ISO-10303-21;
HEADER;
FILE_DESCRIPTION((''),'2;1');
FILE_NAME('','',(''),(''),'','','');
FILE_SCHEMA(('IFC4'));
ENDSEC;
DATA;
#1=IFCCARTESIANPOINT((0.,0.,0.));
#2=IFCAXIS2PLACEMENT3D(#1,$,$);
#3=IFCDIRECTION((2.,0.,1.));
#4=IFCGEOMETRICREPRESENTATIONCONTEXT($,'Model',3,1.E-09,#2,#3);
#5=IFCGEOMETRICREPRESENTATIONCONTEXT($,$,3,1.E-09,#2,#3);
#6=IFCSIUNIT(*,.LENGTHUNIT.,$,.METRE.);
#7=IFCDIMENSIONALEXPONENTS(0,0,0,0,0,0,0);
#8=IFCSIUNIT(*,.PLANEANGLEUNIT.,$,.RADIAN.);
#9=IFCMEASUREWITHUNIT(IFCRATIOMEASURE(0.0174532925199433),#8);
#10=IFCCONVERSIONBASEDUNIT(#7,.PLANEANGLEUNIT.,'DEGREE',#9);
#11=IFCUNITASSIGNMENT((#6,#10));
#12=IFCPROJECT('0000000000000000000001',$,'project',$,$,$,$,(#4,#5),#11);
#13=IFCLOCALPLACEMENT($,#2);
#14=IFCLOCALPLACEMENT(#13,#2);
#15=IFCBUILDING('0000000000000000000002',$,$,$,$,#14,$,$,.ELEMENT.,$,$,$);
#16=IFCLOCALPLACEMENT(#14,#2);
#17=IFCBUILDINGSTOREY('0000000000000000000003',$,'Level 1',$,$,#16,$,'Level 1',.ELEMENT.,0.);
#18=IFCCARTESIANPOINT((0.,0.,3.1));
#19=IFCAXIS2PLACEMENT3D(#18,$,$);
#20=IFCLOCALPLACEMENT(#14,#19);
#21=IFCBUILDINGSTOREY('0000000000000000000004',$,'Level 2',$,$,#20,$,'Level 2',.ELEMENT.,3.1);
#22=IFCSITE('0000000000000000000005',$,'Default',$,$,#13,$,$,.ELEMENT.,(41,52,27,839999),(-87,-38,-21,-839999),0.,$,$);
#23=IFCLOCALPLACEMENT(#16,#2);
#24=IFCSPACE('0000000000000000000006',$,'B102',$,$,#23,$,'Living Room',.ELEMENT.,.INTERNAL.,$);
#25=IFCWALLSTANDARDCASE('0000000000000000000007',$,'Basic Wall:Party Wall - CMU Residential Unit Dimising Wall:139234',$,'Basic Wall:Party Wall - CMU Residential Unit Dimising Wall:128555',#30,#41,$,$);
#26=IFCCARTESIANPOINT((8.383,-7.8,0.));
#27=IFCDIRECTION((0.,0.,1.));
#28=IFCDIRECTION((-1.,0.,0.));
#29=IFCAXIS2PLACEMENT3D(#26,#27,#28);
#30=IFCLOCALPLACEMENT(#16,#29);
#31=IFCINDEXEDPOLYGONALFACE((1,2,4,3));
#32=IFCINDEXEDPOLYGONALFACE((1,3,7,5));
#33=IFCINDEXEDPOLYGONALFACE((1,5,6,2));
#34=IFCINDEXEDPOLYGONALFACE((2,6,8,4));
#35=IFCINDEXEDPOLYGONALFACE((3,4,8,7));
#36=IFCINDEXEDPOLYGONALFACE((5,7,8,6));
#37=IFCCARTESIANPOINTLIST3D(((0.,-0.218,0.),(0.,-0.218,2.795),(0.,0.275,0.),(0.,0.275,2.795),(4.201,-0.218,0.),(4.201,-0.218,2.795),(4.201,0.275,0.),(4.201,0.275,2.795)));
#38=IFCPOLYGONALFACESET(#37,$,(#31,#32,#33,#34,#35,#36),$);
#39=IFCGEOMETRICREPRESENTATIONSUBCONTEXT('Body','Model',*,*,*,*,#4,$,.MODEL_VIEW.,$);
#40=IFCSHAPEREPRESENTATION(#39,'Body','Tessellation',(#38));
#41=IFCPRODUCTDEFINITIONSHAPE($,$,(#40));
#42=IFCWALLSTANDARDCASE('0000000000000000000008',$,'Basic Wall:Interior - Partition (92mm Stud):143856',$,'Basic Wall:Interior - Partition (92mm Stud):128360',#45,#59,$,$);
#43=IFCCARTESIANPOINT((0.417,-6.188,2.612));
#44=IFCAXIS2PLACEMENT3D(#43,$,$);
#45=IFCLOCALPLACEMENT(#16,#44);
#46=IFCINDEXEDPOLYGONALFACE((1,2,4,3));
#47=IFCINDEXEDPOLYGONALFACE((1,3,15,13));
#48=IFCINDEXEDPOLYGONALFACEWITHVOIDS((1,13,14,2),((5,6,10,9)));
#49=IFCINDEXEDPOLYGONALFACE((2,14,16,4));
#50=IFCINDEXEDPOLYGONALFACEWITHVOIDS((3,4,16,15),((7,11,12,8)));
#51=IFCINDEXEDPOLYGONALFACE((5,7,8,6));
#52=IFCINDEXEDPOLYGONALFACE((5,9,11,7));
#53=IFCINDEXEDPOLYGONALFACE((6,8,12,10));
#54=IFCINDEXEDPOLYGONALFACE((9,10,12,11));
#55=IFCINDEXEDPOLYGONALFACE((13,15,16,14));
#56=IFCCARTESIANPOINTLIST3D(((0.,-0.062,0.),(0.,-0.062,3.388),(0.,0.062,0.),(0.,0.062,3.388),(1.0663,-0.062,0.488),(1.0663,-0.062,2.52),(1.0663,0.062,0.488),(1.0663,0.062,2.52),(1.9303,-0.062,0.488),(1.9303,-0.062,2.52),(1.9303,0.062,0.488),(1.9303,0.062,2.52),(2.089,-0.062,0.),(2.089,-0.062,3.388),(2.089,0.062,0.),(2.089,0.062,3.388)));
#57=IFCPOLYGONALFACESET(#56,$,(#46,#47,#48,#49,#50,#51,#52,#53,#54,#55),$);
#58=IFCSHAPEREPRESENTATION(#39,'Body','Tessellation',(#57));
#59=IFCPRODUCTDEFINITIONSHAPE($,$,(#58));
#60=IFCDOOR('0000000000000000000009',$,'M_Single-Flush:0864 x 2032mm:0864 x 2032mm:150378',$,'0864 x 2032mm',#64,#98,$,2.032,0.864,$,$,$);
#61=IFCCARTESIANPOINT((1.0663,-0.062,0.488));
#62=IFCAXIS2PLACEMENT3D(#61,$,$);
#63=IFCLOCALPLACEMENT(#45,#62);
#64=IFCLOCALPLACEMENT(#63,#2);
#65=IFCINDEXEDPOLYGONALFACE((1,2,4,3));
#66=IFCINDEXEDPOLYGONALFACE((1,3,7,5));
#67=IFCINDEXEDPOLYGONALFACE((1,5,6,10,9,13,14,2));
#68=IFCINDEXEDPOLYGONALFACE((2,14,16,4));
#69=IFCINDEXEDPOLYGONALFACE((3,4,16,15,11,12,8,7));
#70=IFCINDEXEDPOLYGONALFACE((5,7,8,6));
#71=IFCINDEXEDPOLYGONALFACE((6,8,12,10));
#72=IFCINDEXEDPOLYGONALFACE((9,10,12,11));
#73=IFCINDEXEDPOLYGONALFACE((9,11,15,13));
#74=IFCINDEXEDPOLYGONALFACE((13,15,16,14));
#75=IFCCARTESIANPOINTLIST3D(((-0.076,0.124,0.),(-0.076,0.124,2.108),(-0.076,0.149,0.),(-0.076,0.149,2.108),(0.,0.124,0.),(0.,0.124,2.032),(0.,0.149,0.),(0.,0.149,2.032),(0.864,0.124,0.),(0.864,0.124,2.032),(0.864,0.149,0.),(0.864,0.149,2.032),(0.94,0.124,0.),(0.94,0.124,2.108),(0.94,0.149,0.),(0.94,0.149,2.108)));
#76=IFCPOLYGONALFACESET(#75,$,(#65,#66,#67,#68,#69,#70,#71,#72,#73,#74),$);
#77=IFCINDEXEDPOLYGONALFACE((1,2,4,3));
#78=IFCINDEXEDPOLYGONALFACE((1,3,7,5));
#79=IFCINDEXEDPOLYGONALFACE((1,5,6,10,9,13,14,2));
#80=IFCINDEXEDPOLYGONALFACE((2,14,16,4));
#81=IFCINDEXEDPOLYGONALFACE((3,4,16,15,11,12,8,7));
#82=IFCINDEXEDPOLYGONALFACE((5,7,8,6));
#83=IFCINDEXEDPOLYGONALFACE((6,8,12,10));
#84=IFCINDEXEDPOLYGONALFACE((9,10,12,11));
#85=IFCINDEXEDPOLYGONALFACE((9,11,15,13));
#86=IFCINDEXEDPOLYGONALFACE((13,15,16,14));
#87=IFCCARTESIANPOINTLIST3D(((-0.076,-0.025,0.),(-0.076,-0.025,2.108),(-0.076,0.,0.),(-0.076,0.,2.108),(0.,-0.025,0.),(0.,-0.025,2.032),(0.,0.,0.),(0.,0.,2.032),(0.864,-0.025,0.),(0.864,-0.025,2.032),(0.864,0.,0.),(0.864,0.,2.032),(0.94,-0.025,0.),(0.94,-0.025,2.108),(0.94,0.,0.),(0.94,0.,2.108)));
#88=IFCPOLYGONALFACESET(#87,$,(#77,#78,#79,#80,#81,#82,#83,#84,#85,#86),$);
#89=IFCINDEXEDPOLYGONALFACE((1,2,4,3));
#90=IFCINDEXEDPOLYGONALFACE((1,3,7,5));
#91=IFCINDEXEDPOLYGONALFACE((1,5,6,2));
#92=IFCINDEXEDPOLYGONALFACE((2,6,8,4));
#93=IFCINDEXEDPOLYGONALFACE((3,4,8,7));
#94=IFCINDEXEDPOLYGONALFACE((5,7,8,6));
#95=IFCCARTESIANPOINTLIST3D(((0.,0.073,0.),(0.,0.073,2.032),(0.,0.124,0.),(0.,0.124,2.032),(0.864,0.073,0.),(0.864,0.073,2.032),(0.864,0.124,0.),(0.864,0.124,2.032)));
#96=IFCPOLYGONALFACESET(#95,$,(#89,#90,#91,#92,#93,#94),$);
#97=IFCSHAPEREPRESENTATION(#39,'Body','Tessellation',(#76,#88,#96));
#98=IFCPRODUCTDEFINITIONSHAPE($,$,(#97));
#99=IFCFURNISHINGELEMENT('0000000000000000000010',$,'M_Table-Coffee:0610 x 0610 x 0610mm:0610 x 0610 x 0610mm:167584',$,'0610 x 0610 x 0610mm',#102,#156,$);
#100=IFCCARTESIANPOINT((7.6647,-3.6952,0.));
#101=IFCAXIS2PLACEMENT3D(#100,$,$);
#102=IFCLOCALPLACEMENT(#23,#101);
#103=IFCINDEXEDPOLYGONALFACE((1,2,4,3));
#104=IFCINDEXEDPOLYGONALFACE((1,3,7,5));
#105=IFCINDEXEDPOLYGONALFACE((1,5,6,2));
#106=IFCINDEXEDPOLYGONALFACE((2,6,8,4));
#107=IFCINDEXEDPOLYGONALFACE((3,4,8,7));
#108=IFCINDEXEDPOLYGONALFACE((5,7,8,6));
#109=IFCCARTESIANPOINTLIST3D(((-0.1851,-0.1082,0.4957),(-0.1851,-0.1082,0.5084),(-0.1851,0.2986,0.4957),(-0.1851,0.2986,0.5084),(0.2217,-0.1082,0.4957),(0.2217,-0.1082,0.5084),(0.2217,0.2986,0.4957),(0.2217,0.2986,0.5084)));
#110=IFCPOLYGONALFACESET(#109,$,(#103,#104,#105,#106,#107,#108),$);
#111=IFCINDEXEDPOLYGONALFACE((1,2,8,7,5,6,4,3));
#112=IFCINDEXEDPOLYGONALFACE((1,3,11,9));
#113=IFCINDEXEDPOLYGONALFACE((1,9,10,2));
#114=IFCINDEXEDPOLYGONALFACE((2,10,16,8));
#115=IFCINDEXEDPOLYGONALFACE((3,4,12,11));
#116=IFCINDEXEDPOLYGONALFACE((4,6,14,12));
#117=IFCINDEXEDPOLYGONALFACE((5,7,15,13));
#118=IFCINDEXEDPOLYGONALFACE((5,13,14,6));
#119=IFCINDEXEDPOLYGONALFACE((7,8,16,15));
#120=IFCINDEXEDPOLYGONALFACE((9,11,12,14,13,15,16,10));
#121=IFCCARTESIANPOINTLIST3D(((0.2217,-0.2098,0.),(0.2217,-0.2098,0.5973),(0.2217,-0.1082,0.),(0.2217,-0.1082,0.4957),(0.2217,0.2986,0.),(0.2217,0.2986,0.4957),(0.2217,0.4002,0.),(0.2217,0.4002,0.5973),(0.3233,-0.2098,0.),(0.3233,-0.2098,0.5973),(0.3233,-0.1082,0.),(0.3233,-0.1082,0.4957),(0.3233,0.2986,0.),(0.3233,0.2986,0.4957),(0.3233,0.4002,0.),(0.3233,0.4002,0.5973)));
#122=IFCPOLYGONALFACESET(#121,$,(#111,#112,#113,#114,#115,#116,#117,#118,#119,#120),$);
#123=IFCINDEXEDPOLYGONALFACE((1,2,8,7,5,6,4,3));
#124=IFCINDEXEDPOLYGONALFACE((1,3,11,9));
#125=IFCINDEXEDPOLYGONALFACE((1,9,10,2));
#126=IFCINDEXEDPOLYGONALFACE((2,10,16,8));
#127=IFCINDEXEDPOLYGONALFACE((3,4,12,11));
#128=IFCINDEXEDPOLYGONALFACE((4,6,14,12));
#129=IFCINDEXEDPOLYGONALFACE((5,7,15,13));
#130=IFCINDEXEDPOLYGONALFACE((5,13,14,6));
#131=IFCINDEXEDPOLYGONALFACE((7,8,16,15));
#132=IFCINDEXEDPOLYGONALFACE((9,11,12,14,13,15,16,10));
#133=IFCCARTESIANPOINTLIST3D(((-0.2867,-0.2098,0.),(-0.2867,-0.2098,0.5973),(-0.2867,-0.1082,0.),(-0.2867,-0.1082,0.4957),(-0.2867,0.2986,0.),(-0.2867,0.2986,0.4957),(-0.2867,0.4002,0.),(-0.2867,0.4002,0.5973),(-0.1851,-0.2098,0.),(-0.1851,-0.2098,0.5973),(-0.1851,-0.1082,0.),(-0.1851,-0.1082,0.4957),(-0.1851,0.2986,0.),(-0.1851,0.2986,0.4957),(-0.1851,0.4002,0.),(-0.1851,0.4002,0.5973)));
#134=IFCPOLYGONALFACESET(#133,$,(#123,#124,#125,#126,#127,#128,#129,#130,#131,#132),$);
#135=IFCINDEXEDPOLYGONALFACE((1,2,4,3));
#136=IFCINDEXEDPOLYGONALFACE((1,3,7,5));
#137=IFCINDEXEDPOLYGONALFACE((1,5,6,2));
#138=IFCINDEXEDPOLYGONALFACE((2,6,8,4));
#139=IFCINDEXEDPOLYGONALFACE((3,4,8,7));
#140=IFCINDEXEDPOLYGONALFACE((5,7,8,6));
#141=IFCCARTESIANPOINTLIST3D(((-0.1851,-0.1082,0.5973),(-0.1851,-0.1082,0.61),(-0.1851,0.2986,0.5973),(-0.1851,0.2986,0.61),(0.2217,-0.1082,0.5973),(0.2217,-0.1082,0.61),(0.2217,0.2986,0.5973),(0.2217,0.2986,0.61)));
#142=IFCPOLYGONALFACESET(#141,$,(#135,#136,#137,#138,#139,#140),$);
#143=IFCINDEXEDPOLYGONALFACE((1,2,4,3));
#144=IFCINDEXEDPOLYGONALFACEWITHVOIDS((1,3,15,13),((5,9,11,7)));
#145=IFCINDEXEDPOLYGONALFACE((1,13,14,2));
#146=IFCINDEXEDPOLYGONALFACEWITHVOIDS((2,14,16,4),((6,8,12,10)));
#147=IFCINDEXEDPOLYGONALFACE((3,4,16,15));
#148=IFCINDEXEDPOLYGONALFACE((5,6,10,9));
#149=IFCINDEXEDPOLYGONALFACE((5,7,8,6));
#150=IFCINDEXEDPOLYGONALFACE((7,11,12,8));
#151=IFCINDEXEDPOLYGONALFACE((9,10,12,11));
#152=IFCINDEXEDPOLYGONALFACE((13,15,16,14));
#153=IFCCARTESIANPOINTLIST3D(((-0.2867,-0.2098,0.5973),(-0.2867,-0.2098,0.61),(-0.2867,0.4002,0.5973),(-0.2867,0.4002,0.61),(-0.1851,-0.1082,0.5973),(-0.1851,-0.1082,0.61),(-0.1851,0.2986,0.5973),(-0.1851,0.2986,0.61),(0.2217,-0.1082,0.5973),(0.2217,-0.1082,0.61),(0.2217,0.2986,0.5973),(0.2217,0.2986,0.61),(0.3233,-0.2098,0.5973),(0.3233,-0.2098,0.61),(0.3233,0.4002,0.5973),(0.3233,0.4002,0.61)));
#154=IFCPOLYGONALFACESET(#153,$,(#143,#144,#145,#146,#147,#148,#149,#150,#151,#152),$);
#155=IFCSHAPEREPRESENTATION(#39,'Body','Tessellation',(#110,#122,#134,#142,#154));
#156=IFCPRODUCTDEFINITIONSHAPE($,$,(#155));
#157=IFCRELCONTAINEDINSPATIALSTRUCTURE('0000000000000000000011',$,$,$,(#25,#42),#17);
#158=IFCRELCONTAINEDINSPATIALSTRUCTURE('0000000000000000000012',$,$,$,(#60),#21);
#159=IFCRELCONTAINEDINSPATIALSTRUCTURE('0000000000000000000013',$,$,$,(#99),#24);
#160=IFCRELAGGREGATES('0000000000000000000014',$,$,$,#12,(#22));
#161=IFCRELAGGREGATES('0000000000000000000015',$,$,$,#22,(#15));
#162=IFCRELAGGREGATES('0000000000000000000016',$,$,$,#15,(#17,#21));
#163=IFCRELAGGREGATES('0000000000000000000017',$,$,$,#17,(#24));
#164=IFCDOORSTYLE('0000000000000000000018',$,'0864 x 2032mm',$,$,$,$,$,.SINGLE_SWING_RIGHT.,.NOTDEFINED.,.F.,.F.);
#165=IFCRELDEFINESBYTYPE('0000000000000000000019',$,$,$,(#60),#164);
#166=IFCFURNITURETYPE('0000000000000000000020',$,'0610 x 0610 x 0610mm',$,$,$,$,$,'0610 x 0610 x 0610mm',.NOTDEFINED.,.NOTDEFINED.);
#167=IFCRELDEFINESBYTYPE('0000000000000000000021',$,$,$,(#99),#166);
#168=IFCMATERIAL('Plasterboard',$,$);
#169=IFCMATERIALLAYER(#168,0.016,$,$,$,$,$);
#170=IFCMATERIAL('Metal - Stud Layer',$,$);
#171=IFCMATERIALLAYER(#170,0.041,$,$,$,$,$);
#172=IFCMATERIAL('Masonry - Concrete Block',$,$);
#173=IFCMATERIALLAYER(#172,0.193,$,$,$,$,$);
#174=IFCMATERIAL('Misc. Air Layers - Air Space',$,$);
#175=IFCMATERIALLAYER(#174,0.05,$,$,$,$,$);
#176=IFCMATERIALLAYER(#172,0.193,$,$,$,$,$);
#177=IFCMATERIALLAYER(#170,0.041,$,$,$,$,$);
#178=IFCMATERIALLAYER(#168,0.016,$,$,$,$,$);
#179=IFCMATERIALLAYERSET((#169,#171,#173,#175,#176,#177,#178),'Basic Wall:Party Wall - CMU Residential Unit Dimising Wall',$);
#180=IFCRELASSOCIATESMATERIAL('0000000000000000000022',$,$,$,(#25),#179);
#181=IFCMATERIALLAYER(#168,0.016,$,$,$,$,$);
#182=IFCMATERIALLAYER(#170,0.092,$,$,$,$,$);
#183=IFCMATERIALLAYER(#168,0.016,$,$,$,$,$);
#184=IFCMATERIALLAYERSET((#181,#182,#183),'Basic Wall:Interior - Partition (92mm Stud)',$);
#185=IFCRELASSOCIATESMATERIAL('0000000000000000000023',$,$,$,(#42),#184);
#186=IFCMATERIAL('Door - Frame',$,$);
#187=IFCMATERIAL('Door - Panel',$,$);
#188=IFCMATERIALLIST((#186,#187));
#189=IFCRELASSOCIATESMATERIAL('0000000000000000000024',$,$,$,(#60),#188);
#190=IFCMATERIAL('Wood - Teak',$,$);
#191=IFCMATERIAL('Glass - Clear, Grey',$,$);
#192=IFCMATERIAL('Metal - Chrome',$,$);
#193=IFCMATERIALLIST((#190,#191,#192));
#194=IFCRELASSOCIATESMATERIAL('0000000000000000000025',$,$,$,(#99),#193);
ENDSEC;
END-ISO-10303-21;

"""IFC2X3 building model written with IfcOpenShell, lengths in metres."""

from ifc_helpers import new_model, entity, si_unit, converted_unit, direction, frame, frame_2d, origin, origin_2d_with_axis, place, context, subcontext, project, spatial, polyline, rectangle, outline, extrude, clip, bounded_halfspace, source, transform, mapped, material, material_list, layer, layer_set, layer_usage, type_object, type_shapes, element, fill, save


model = new_model("IFC2X3")

# Units and contexts
model_context = context("Model", 3, precision=1e-09, world=origin(), true_north=direction((2.0, 0.0, 1.0)))
context_of_model = context(None, 3, precision=1e-09, world=origin(), true_north=direction((2.0, 0.0, 1.0)))
body_context = subcontext(model_context, "Body", "Model", "MODEL_VIEW")
ifc_project = project(units=[si_unit("LENGTHUNIT", "METRE"), converted_unit("PLANEANGLEUNIT", "DEGREE", entity("IfcRatioMeasure", 0.0174532925199433), si_unit("PLANEANGLEUNIT", "RADIAN"), dimensions=[0, 0, 0, 0, 0, 0, 0])], contexts=[model_context, context_of_model])

# Site, building, storey
site_placement = place(None, origin())
site = spatial("IfcSite", under=ifc_project, at=site_placement, Name="Default", CompositionType="ELEMENT", RefLatitude=(41, 52, 27, 839999), RefLongitude=(-87, -38, -21, -839999), RefElevation=0.0)
building_placement = place(site_placement, origin())
building = spatial("IfcBuilding", under=site, at=building_placement, CompositionType="ELEMENT")
storey_1_placement = place(building_placement, origin())
storey_1 = spatial("IfcBuildingStorey", under=building, at=storey_1_placement, Name="Level 1", LongName="Level 1", CompositionType="ELEMENT", Elevation=0.0)

# Shared definitions
ifc_material_1 = material(Name="Plasterboard")
ifc_layer_1 = layer(ifc_material_1, 0.016)
ifc_material_2 = material(Name="Metal - Stud Layer")
ifc_layer_2 = layer(ifc_material_2, 0.092)
ifc_layer_3 = layer(ifc_material_1, 0.016)
ifc_layer_set_1 = layer_set([ifc_layer_1, ifc_layer_2, ifc_layer_3], Name="Basic Wall:Interior - Partition (92mm Stud)")
ifc_material_3 = material(Name="Door - Frame")
ifc_material_4 = material(Name="Door - Panel")

# Wall
ifc_layer_4 = layer(ifc_material_1, 0.016)
ifc_layer_5 = layer(ifc_material_2, 0.041)
ifc_material_5 = material(Name="Masonry - Concrete Block")
ifc_layer_6 = layer(ifc_material_5, 0.193)
ifc_material_6 = material(Name="Misc. Air Layers - Air Space")
ifc_layer_7 = layer(ifc_material_6, 0.05)
ifc_layer_8 = layer(ifc_material_5, 0.193)
ifc_layer_9 = layer(ifc_material_2, 0.041)
ifc_layer_10 = layer(ifc_material_1, 0.016)
ifc_layer_set_2 = layer_set([ifc_layer_4, ifc_layer_5, ifc_layer_6, ifc_layer_7, ifc_layer_8, ifc_layer_9, ifc_layer_10], Name="Basic Wall:Party Wall - CMU Residential Unit Dimising Wall")
ifc_layer_usage_1 = layer_usage(ifc_layer_set_2, "AXIS2", "NEGATIVE", 0.275)
wall_1_placement = place(storey_1_placement, frame((8.383, -7.8, 0.0), z_axis=(0.0, 0.0, 1.0), x_axis=(-1.0, 0.0, 0.0)))
element("IfcWallStandardCase", 1, at=wall_1_placement, inside=storey_1, material=ifc_layer_usage_1, Name="Basic Wall:Party Wall - CMU Residential Unit Dimising Wall:139234", ObjectType="Basic Wall:Party Wall - CMU Residential Unit Dimising Wall:128555", context=body_context, shape_type="Clipping", body=[
    clip(clip(extrude(rectangle(XDim=4.201, YDim=0.55, at=frame_2d((2.1005, 0.0), x_axis=(-1.0, 0.0))), origin(), (0.0, 0.0, 1.0), 2.795), bounded_halfspace(frame((0.0, -0.218, 2.795), z_axis=(0.0, 1.0, 0.0), x_axis=(-1.0, 0.0, 0.0)), True, frame((0.0, -0.218, 2.795), z_axis=(0.0, 1.0, 0.0), x_axis=(-1.0, 0.0, 0.0)), polyline([(0.0, 0.0), (-3.708, 0.0), (-4.201, 0.0), (-4.201, -2.795), (0.0, -2.795), (0.0, 0.0)]))), bounded_halfspace(frame((4.201, 0.275, 0.0), z_axis=(-1.0, 0.0, 0.0), x_axis=(0.0, -1.0, 0.0)), True, frame((4.201, 0.275, 0.0), z_axis=(-1.0, 0.0, 0.0), x_axis=(0.0, -1.0, 0.0)), polyline([(0.0, 0.0), (0.493, 0.0), (0.493, 2.795), (0.0, 2.795), (0.0, 0.0)]))),
])

# Wall, opening
ifc_layer_usage_2 = layer_usage(ifc_layer_set_1, "AXIS2", "NEGATIVE", 0.062)
wall_2_placement = place(storey_1_placement, frame((0.417, -6.188, 2.612)))
wall_2 = element("IfcWallStandardCase", 2, at=wall_2_placement, inside=storey_1, material=ifc_layer_usage_2, Name="Basic Wall:Interior - Partition (92mm Stud):143856", ObjectType="Basic Wall:Interior - Partition (92mm Stud):128360", context=body_context, shape_type="SweptSolid", body=[
    extrude(rectangle(XDim=2.089, YDim=0.124, at=frame_2d((1.0445, 0.0), x_axis=(-1.0, 0.0))), origin(), (0.0, 0.0, 1.0), 3.388),
])
opening_1_placement = place(wall_2_placement, frame((1.0663, -0.062, 0.488)))
opening_1 = element("IfcOpeningElement", 3, at=opening_1_placement, cuts=wall_2, ObjectType="Opening", context=body_context, shape_type="SweptSolid", body=[
    extrude(rectangle(XDim=0.864, YDim=2.032, at=frame_2d((1.016, 0.432), x_axis=(0.0, 1.0))), frame((0.0, 0.0, 0.0), z_axis=(0.0, 1.0, 0.0), x_axis=(0.0, 0.0, 1.0)), (0.0, 0.0, 1.0), 0.124),
])

# Shared definitions
storey_2_placement = place(building_placement, frame((0.0, 0.0, 3.1)))
storey_2 = spatial("IfcBuildingStorey", under=building, at=storey_2_placement, Name="Level 2", LongName="Level 2", CompositionType="ELEMENT", Elevation=3.1)

# Door
ifc_material_list_1 = material_list([ifc_material_3, ifc_material_4])
door_style_1 = type_object("IfcDoorStyle", Name="0864 x 2032mm", ConstructionType="NOTDEFINED", OperationType="SINGLE_SWING_RIGHT", ParameterTakesPrecedence=False, Sizeable=False)
shared_shape_1 = source(origin(), body_context, "Body", "SweptSolid", [
    extrude(outline(polyline([(-0.508, -1.073), (0.508, -1.073), (0.508, 1.035), (0.432, 1.035), (0.432, -0.997), (-0.432, -0.997), (-0.432, 1.035), (-0.508, 1.035), (-0.508, -1.073)])), frame((0.432, 0.124, 1.035), z_axis=(0.0, 1.0, 0.0), x_axis=(1.0, 0.0, 0.0)), (0.0, 0.0, 1.0), 0.025),
    extrude(outline(polyline([(-1.073, -0.508), (1.035, -0.508), (1.035, -0.432), (-0.997, -0.432), (-0.997, 0.432), (1.035, 0.432), (1.035, 0.508), (-1.073, 0.508), (-1.073, -0.508)])), frame((0.432, -0.025, 1.035), z_axis=(0.0, 1.0, 0.0), x_axis=(0.0, 0.0, -1.0)), (0.0, 0.0, 1.0), 0.025),
    extrude(rectangle(XDim=0.051, YDim=0.864, at=origin_2d_with_axis()), frame((0.432, 0.0985, 0.0), z_axis=(0.0, 0.0, 1.0), x_axis=(0.0, 1.0, 0.0)), (0.0, 0.0, 1.0), 2.032),
])
type_shapes(door_style_1, [shared_shape_1])
door_1_placement = place(opening_1_placement, origin())
door_1 = element("IfcDoor", 4, at=door_1_placement, inside=storey_2, type_object=door_style_1, material=ifc_material_list_1, Name="M_Single-Flush:0864 x 2032mm:0864 x 2032mm:150378", ObjectType="0864 x 2032mm", OverallHeight=2.032, OverallWidth=0.864, context=body_context, shape_type="MappedRepresentation", body=[
    mapped(shared_shape_1, transform((0.0, 0.0, 0.0), scale=1.0)),
])
fill(opening_1, door_1)

# Shared definitions
space_1_placement = place(storey_1_placement, origin())
space_1 = spatial("IfcSpace", under=storey_1, at=space_1_placement, Name="B102", LongName="Living Room", CompositionType="ELEMENT", InteriorOrExteriorSpace="INTERNAL")

# Furnishing element
ifc_material_7 = material(Name="Wood - Teak")
ifc_material_8 = material(Name="Glass - Clear, Grey")
ifc_material_9 = material(Name="Metal - Chrome")
ifc_material_list_2 = material_list([ifc_material_7, ifc_material_8, ifc_material_9])
furniture_type_1 = type_object("IfcFurnitureType", Name="0610 x 0610 x 0610mm", ElementType="0610 x 0610 x 0610mm", AssemblyPlace="NOTDEFINED")
shared_shape_2 = source(origin(), body_context, "Body", "SweptSolid", [
    extrude(rectangle(XDim=0.4068, YDim=0.4068, at=origin_2d_with_axis()), frame((0.0183, 0.0952, 0.4957), z_axis=(0.0, 0.0, 1.0), x_axis=(-1.0, 0.0, 0.0)), (0.0, 0.0, 1.0), 0.0127),
    extrude(outline(polyline([(-0.2732, -0.305), (0.324, -0.305), (0.324, 0.305), (-0.2732, 0.305), (-0.2732, 0.2034), (0.2225, 0.2034), (0.2225, -0.2034), (-0.2732, -0.2034), (-0.2732, -0.305)])), frame((0.2217, 0.0952, 0.2732), z_axis=(1.0, 0.0, 0.0), x_axis=(0.0, 0.0, 1.0)), (0.0, 0.0, 1.0), 0.1016),
    extrude(outline(polyline([(-0.305, -0.3241), (0.305, -0.3241), (0.305, 0.2733), (0.2034, 0.2733), (0.2034, -0.2224), (-0.2034, -0.2224), (-0.2034, 0.2733), (-0.305, 0.2733), (-0.305, -0.3241)])), frame((-0.2867, 0.0952, 0.2733), z_axis=(1.0, 0.0, 0.0), x_axis=(0.0, -1.0, 0.0)), (0.0, 0.0, 1.0), 0.1016),
    extrude(rectangle(XDim=0.4068, YDim=0.4068, at=origin_2d_with_axis()), frame((0.0183, 0.0952, 0.5973), z_axis=(0.0, 0.0, 1.0), x_axis=(-1.0, 0.0, 0.0)), (0.0, 0.0, 1.0), 0.0127),
    extrude(outline(polyline([(-0.305, -0.305), (0.305, -0.305), (0.305, 0.305), (-0.305, 0.305), (-0.305, -0.305)]), holes=[polyline([(-0.2034, -0.2034), (-0.2034, 0.2034), (0.2034, 0.2034), (0.2034, -0.2034), (-0.2034, -0.2034)])]), frame((0.0183, 0.0952, 0.5973), z_axis=(0.0, 0.0, 1.0), x_axis=(-1.0, 0.0, 0.0)), (0.0, 0.0, 1.0), 0.0127),
])
type_shapes(furniture_type_1, [shared_shape_2])
furnishing_1_placement = place(space_1_placement, frame((7.6647, -3.6952, 0.0)))
element("IfcFurnishingElement", 5, at=furnishing_1_placement, inside=space_1, type_object=furniture_type_1, material=ifc_material_list_2, Name="M_Table-Coffee:0610 x 0610 x 0610mm:0610 x 0610 x 0610mm:167584", ObjectType="0610 x 0610 x 0610mm", context=body_context, shape_type="MappedRepresentation", body=[
    mapped(shared_shape_2, transform((0.0, 0.0, 0.0), scale=1.0)),
])

save(model, "model.ifc")
